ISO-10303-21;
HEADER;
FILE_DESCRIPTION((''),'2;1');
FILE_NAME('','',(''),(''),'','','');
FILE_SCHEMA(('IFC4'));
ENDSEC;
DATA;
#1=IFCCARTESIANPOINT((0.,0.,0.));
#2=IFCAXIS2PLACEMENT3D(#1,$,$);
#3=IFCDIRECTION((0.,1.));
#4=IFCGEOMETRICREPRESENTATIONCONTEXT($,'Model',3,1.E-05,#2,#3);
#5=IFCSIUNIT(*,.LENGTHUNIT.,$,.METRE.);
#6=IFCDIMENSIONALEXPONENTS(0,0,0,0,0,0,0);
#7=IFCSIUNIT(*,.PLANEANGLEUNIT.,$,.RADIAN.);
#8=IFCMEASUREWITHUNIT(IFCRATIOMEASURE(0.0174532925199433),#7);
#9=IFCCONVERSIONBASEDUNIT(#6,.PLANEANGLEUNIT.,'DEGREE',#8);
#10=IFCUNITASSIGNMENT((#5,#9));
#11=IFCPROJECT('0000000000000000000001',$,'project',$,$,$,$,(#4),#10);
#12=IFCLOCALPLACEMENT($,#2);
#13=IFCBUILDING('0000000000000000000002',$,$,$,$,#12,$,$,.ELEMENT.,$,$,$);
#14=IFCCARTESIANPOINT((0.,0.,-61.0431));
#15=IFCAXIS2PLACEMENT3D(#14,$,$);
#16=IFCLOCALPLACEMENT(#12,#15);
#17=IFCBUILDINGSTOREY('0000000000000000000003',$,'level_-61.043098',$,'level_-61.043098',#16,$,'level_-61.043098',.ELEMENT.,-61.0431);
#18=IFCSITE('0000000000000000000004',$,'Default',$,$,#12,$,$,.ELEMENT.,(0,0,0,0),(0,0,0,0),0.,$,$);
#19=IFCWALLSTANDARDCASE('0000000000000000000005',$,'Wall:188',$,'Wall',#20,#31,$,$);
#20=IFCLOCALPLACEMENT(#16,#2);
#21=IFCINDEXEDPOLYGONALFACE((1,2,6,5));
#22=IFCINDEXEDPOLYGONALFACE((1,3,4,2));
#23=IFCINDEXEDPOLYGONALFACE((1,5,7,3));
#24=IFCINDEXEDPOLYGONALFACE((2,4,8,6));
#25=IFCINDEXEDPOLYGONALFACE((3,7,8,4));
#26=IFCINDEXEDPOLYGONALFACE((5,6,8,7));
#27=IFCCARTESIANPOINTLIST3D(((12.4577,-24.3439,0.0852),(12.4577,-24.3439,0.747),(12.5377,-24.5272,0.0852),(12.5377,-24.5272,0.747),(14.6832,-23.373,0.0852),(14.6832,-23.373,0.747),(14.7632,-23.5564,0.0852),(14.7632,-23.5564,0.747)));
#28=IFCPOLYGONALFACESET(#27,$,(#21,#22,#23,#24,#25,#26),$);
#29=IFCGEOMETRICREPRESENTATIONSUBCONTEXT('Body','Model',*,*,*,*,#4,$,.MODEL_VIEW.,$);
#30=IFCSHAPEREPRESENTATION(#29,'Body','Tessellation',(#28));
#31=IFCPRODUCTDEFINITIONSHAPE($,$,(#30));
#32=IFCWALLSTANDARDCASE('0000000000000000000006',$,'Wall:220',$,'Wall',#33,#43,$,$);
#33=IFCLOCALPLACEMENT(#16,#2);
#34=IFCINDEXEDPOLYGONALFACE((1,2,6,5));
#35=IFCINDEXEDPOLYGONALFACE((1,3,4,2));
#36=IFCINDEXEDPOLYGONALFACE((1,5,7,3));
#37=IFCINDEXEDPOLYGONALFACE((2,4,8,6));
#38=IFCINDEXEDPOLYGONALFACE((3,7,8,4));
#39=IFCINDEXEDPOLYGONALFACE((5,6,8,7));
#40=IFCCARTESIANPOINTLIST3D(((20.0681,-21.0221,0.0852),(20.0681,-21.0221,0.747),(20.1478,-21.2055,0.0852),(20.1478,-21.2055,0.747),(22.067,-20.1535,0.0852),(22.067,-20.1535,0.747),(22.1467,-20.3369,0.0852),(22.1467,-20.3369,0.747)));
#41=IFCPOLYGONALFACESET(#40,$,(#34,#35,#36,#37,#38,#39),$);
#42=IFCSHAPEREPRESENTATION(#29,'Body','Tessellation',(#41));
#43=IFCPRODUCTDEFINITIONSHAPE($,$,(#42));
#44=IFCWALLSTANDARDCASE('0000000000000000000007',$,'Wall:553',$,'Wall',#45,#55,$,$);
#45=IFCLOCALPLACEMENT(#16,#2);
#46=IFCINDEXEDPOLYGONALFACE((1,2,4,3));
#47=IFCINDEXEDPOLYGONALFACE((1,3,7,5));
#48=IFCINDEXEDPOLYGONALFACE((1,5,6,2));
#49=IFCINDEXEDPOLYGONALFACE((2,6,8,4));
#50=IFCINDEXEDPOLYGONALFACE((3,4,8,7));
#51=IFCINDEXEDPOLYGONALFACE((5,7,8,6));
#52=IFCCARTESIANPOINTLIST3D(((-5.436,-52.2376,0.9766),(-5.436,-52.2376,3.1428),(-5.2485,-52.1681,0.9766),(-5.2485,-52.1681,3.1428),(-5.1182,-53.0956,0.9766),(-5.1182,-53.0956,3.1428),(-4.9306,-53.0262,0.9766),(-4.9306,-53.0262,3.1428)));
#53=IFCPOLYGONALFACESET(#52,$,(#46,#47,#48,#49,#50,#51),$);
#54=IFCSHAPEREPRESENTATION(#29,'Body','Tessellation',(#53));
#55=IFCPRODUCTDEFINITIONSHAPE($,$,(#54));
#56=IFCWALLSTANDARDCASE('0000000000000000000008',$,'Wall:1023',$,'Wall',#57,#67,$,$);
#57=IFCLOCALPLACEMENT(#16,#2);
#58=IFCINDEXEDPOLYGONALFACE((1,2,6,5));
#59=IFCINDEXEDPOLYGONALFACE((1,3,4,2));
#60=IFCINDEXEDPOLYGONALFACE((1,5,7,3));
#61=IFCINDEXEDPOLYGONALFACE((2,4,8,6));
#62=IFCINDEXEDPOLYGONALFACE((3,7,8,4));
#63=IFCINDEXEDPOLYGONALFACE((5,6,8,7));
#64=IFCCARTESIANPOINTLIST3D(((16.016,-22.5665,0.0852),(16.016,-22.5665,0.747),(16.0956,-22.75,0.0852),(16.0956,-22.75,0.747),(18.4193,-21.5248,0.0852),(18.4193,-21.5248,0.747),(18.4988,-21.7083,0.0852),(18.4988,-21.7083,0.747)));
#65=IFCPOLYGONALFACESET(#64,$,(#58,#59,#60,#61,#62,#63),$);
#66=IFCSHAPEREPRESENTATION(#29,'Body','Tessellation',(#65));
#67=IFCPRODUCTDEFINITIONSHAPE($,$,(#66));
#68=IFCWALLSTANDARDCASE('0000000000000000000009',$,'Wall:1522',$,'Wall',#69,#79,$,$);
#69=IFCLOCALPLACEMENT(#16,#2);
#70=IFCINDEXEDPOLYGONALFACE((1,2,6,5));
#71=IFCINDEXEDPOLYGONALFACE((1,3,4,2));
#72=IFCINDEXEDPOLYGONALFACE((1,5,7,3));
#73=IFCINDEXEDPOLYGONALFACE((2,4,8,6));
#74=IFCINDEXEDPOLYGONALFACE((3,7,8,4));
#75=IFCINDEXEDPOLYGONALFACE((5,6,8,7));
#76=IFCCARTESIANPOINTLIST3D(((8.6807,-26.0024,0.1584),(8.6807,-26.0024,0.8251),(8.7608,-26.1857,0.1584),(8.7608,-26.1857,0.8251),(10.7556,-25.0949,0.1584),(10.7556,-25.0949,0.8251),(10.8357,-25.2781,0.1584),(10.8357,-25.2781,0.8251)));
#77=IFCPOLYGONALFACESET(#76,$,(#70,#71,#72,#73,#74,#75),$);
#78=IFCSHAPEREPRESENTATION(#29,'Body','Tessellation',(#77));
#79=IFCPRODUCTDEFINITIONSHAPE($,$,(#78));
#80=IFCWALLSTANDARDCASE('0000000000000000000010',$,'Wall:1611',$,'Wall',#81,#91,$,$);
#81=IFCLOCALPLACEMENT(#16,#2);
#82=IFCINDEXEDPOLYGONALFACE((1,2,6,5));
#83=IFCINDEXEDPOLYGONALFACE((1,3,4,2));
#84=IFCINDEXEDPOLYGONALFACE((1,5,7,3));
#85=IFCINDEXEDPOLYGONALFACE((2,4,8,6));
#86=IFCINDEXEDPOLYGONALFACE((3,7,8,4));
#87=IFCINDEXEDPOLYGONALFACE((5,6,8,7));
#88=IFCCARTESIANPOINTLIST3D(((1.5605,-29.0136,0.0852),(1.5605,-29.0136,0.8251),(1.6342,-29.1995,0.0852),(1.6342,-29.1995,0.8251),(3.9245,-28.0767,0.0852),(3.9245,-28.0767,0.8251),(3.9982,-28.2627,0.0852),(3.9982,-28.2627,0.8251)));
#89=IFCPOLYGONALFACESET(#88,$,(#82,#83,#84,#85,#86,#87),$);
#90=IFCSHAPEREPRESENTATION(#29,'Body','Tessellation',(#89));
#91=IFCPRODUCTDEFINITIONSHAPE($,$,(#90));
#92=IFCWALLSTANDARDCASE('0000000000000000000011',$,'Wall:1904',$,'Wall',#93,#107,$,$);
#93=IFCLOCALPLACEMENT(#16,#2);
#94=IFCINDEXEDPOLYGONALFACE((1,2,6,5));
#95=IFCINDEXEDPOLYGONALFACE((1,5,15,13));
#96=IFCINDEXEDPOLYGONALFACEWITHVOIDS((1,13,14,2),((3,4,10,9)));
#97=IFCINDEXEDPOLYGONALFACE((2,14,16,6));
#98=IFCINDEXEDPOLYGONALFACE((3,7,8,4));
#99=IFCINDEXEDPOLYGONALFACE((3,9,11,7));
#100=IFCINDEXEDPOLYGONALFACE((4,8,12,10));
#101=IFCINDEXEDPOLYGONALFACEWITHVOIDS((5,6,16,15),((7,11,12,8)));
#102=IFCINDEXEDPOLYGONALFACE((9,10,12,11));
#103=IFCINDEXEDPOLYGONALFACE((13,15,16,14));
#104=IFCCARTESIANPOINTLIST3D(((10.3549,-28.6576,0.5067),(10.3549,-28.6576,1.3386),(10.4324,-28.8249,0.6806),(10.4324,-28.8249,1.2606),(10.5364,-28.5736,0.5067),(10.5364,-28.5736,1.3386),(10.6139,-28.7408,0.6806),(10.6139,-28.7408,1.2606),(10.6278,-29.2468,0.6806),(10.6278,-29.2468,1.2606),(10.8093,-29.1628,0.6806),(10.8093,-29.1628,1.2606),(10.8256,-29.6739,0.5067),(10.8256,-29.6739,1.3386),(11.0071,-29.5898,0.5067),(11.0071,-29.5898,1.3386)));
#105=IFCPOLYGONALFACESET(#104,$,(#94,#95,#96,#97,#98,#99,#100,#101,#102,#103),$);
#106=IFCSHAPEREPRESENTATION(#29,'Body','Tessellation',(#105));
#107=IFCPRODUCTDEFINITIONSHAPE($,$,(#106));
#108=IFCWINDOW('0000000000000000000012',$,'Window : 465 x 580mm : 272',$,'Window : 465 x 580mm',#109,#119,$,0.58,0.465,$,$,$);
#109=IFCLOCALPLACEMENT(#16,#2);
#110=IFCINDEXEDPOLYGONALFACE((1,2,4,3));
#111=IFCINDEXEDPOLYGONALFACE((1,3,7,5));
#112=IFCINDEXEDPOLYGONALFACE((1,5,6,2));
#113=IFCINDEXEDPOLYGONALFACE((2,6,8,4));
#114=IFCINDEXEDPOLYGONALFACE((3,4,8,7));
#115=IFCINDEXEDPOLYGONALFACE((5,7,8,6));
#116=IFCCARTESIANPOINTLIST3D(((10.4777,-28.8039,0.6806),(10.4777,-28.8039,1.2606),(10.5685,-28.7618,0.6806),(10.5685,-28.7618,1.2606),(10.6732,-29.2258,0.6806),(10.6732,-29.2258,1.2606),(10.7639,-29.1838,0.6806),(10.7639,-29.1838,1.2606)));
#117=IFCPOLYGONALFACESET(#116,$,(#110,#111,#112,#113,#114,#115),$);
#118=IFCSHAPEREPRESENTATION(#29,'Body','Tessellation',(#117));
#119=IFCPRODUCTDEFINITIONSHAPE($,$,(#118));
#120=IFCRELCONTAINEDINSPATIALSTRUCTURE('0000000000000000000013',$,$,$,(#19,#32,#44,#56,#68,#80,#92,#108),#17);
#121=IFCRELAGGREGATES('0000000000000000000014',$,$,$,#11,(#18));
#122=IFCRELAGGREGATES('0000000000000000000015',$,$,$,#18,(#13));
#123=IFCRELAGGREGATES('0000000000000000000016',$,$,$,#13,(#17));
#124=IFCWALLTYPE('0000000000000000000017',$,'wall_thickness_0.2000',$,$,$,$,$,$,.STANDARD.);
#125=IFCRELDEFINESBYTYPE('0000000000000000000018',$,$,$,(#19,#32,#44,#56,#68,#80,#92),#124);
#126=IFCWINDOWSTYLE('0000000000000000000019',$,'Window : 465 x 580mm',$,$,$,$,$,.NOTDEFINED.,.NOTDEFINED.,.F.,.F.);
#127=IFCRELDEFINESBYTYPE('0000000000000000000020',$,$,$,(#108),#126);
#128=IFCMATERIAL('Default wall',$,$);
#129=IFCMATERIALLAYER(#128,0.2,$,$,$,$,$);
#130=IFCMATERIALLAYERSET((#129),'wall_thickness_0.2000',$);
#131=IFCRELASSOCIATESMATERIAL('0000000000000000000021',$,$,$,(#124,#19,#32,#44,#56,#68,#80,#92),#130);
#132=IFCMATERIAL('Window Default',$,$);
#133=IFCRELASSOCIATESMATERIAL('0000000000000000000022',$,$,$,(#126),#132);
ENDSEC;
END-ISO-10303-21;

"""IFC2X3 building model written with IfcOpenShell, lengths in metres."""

from ifc_helpers import new_model, entity, si_unit, converted_unit, direction, frame, frame_2d, origin, origin_2d_with_axis, place, context, subcontext, project, spatial, polyline, rectangle, outline, extrude, source, transform, mapped, material, layer, layer_set, layer_usage, type_object, type_shapes, element, fill, save


model = new_model("IFC2X3")

# Units and contexts
model_context = context("Model", 3, precision=1e-05, world=origin(), true_north=direction((0.0, 1.0)))
body_context = subcontext(model_context, "Body", "Model", "MODEL_VIEW")
ifc_project = project(units=[si_unit("LENGTHUNIT", "METRE"), converted_unit("PLANEANGLEUNIT", "DEGREE", entity("IfcRatioMeasure", 0.0174532925199433), si_unit("PLANEANGLEUNIT", "RADIAN"), dimensions=[0, 0, 0, 0, 0, 0, 0])], contexts=[model_context])

# Site, building, storey
placement_1 = place(None, origin())
site = spatial("IfcSite", under=ifc_project, at=placement_1, Name="Default", CompositionType="ELEMENT", RefLatitude=(0, 0, 0, 0), RefLongitude=(0, 0, 0, 0), RefElevation=0.0)
building = spatial("IfcBuilding", under=site, at=placement_1, CompositionType="ELEMENT")
storey_placement = place(placement_1, frame((0.0, 0.0, -61.0431)))
storey = spatial("IfcBuildingStorey", under=building, at=storey_placement, Name="level_-61.043098", ObjectType="level_-61.043098", LongName="level_-61.043098", CompositionType="ELEMENT", Elevation=-61.0431)

# Walls
ifc_material_1 = material(Name="Default wall")
ifc_layer = layer(ifc_material_1, 0.2)
ifc_layer_set = layer_set([ifc_layer], Name="wall_thickness_0.2000")
ifc_layer_usage = layer_usage(ifc_layer_set, "AXIS2", "POSITIVE", -0.1)
wall_type = type_object("IfcWallType", Name="wall_thickness_0.2000", PredefinedType="STANDARD", material=ifc_layer_set)
placement_2 = place(placement_1, frame((0.0, 0.0, -60.9579)))
wall_1_placement = place(placement_2, frame((12.4977, -24.4356, 0.0), z_axis=(0.0, 0.0, 1.0), x_axis=(0.916577, 0.399858, 0.0)))
element("IfcWallStandardCase", 1, at=wall_1_placement, inside=storey, type_object=wall_type, material=ifc_layer_usage, Name="Wall:188", ObjectType="Wall", context=body_context, shape_type="SweptSolid", body=[
    extrude(outline(polyline([(2.4281, -0.1), (2.4281, 0.1), (0.0, 0.1), (0.0, -0.1), (2.4281, -0.1)])), origin(), (0.0, 0.0, 1.0), 0.6618),
])
placement_3 = place(placement_1, frame((0.0, 0.0, -60.9579)))
wall_2_placement = place(placement_3, frame((20.1079, -21.1138, 0.0), z_axis=(0.0, 0.0, 1.0), x_axis=(0.917144, 0.398557, 0.0)))
element("IfcWallStandardCase", 2, at=wall_2_placement, inside=storey, type_object=wall_type, material=ifc_layer_usage, Name="Wall:220", ObjectType="Wall", context=body_context, shape_type="SweptSolid", body=[
    extrude(outline(polyline([(2.1795, -0.1), (2.1795, 0.1), (0.0, 0.1), (0.0, -0.1), (2.1795, -0.1)])), origin(), (0.0, 0.0, 1.0), 0.6618),
])
placement_4 = place(placement_1, frame((0.0, 0.0, -60.0665)))
wall_3_placement = place(placement_4, frame((-5.0244, -53.0609, 0.0), z_axis=(0.0, 0.0, 1.0), x_axis=(-0.347367, 0.937729, 0.0)))
element("IfcWallStandardCase", 3, at=wall_3_placement, inside=storey, type_object=wall_type, material=ifc_layer_usage, Name="Wall:553", ObjectType="Wall", context=body_context, shape_type="SweptSolid", body=[
    extrude(outline(polyline([(0.915, -0.1), (0.915, 0.1), (0.0, 0.1), (0.0, -0.1), (0.915, -0.1)])), origin(), (0.0, 0.0, 1.0), 2.1662),
])
placement_5 = place(placement_1, frame((0.0, 0.0, -60.9579)))
wall_4_placement = place(placement_5, frame((16.0558, -22.6582, 0.0), z_axis=(0.0, 0.0, 1.0), x_axis=(0.917529, 0.397668, 0.0)))
element("IfcWallStandardCase", 4, at=wall_4_placement, inside=storey, type_object=wall_type, material=ifc_layer_usage, Name="Wall:1023", ObjectType="Wall", context=body_context, shape_type="SweptSolid", body=[
    extrude(outline(polyline([(2.6193, -0.1), (2.6193, 0.1), (0.0, 0.1), (0.0, -0.1), (2.6193, -0.1)])), origin(), (0.0, 0.0, 1.0), 0.6618),
])

# Shared definitions
ifc_material_2 = material(Name="Window Default")

# Walls
placement_6 = place(placement_1, frame((0.0, 0.0, -60.8847)))
wall_5_placement = place(placement_6, frame((8.7207, -26.0941, 0.0), z_axis=(0.0, 0.0, 1.0), x_axis=(0.916189, 0.400745, 0.0)))
element("IfcWallStandardCase", 5, at=wall_5_placement, inside=storey, type_object=wall_type, material=ifc_layer_usage, Name="Wall:1522", ObjectType="Wall", context=body_context, shape_type="SweptSolid", body=[
    extrude(outline(polyline([(2.2647, -0.1), (2.2647, 0.1), (0.0, 0.1), (0.0, -0.1), (2.2647, -0.1)])), origin(), (0.0, 0.0, 1.0), 0.6667),
])
placement_7 = place(placement_1, frame((0.0, 0.0, -60.9579)))
wall_6_placement = place(placement_7, frame((1.5973, -29.1065, 0.0), z_axis=(0.0, 0.0, 1.0), x_axis=(0.929661, 0.368415, 0.0)))
element("IfcWallStandardCase", 6, at=wall_6_placement, inside=storey, type_object=wall_type, material=ifc_layer_usage, Name="Wall:1611", ObjectType="Wall", context=body_context, shape_type="SweptSolid", body=[
    extrude(outline(polyline([(2.5429, -0.1), (2.5429, 0.1), (0.0, 0.1), (0.0, -0.1), (2.5429, -0.1)])), origin(), (0.0, 0.0, 1.0), 0.7399),
])

# Wall, opening, window
placement_8 = place(placement_1, frame((0.0, 0.0, -60.5364)))
wall_7_placement = place(placement_8, frame((10.4456, -28.6156, 0.0), z_axis=(0.0, 0.0, 1.0), x_axis=(0.42027, -0.907399, 0.0)))
wall_7 = element("IfcWallStandardCase", 7, at=wall_7_placement, inside=storey, type_object=wall_type, material=ifc_layer_usage, Name="Wall:1904", ObjectType="Wall", context=body_context, shape_type="SweptSolid", body=[
    extrude(outline(polyline([(1.12, -0.1), (1.12, 0.1), (0.0, 0.1), (0.0, -0.1), (1.12, -0.1)])), origin(), (0.0, 0.0, 1.0), 0.8319),
])
opening_1_placement = place(wall_7_placement, frame((0.1843, -0.1, 0.1739)))
opening_1 = element("IfcOpeningElement", 8, at=opening_1_placement, cuts=wall_7, ObjectType="Opening", context=body_context, shape_type="SweptSolid", body=[
    extrude(rectangle(XDim=0.465, YDim=0.58, at=frame_2d((0.29, 0.2325), x_axis=(0.0, 1.0))), frame((0.0, 0.0, 0.0), z_axis=(0.0, 1.0, 0.0), x_axis=(0.0, 0.0, 1.0)), (0.0, 0.0, 1.0), 0.2),
])
window_style_1 = type_object("IfcWindowStyle", Name="Window : 465 x 580mm", ConstructionType="NOTDEFINED", OperationType="NOTDEFINED", ParameterTakesPrecedence=False, Sizeable=False, material=ifc_material_2)
shared_shape_1 = source(origin(), body_context, "Body", "SweptSolid", [
    extrude(rectangle(XDim=0.1, YDim=0.465, at=origin_2d_with_axis()), frame((0.2325, 0.1, 0.0), z_axis=(0.0, 0.0, 1.0), x_axis=(0.0, 1.0, 0.0)), (0.0, 0.0, 1.0), 0.58),
])
type_shapes(window_style_1, [shared_shape_1])
window_1_placement = place(opening_1_placement, origin())
window_1 = element("IfcWindow", 9, at=window_1_placement, inside=storey, type_object=window_style_1, Name="Window : 465 x 580mm : 272", ObjectType="Window : 465 x 580mm", OverallHeight=0.58, OverallWidth=0.465, context=body_context, shape_type="MappedRepresentation", body=[
    mapped(shared_shape_1, transform((0.0, 0.0, 0.0), scale=1.0)),
])
fill(opening_1, window_1)

save(model, "model.ifc")
